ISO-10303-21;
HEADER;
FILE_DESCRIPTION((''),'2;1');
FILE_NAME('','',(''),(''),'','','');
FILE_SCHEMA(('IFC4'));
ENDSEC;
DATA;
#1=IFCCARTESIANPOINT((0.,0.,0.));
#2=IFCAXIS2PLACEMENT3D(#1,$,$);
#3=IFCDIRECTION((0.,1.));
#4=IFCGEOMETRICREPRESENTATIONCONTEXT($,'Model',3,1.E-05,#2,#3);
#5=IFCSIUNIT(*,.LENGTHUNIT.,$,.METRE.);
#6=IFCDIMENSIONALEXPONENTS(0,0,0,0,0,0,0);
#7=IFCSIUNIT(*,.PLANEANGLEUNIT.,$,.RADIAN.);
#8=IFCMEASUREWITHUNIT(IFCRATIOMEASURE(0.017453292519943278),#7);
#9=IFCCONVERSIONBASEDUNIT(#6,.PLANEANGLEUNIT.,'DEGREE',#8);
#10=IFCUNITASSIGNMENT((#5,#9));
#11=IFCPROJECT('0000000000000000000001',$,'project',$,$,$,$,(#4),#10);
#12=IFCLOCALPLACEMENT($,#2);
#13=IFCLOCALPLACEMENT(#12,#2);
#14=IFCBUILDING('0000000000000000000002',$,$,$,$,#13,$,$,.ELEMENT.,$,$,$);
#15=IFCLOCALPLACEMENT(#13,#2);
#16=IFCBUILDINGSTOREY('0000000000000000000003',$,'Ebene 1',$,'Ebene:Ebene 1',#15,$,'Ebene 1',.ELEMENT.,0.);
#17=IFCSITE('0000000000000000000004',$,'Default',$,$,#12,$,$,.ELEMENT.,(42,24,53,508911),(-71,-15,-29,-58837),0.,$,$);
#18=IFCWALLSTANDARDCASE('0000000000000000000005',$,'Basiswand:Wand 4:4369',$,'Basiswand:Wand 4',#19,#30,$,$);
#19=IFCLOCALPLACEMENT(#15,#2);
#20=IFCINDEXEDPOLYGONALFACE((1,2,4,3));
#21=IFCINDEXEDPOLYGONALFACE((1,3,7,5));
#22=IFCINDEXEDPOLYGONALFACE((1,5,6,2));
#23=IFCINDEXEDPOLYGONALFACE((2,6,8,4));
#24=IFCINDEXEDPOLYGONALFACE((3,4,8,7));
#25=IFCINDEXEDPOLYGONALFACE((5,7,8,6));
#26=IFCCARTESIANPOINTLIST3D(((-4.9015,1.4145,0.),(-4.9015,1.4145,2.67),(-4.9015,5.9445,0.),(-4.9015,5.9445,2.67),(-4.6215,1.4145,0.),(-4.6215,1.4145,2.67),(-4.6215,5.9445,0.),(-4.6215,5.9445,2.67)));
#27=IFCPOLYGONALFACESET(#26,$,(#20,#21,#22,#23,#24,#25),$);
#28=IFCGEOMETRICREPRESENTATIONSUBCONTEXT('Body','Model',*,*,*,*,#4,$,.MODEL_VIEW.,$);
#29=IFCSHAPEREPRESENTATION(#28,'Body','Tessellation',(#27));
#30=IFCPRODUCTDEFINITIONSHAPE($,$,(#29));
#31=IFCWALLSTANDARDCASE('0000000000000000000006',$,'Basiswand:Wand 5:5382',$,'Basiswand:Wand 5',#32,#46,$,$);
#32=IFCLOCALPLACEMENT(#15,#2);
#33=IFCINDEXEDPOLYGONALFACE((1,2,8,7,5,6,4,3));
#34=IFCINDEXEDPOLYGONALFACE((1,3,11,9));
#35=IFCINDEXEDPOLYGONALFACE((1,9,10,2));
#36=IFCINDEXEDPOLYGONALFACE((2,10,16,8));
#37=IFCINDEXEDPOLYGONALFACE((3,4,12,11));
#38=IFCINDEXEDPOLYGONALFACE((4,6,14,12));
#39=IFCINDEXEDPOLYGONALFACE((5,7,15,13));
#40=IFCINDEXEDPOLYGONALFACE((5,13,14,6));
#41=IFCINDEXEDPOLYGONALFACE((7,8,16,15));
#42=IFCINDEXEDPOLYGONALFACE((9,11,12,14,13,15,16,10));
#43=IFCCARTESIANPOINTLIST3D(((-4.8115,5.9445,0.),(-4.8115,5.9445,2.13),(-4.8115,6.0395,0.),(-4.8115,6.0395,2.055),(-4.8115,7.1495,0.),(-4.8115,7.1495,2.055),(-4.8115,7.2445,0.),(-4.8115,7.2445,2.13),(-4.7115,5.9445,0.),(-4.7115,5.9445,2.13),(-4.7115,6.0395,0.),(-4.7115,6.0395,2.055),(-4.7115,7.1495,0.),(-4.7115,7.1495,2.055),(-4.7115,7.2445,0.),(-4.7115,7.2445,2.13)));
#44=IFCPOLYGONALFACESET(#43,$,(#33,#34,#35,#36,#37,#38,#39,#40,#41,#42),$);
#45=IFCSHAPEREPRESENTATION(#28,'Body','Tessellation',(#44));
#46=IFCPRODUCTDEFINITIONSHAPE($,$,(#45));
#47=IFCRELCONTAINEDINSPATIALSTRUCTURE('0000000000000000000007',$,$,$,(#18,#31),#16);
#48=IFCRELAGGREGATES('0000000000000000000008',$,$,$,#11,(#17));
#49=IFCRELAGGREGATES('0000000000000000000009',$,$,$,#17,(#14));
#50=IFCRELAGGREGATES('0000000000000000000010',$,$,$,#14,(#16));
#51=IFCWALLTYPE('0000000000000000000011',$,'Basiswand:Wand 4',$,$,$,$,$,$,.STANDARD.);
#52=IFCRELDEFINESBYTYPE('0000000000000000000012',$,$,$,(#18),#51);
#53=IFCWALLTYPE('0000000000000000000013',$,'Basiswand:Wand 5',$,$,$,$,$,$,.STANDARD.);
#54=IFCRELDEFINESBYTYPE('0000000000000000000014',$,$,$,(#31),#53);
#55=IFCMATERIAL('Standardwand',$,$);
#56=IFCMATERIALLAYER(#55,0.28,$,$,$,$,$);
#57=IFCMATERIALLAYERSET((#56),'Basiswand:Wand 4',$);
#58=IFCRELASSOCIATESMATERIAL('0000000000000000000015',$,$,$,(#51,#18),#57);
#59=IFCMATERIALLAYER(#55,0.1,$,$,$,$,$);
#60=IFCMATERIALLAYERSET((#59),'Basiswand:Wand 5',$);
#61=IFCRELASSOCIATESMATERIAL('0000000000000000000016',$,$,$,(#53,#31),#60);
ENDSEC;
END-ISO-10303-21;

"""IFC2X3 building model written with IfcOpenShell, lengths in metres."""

from ifc_helpers import new_model, entity, si_unit, converted_unit, direction, frame, frame_2d, origin, place, context, subcontext, project, spatial, rectangle, extrude, material, layer, layer_set, layer_usage, type_object, element, save


model = new_model("IFC2X3")

# Units and contexts
model_context = context("Model", 3, precision=1e-05, world=origin(), true_north=direction((0.0, 1.0)))
body_context = subcontext(model_context, "Body", "Model", "MODEL_VIEW")
ifc_project = project(units=[si_unit("LENGTHUNIT", "METRE"), converted_unit("PLANEANGLEUNIT", "DEGREE", entity("IfcRatioMeasure", 0.017453292519943278), si_unit("PLANEANGLEUNIT", "RADIAN"), dimensions=[0, 0, 0, 0, 0, 0, 0])], contexts=[model_context])

# Site, building, storey
site_placement = place(None, origin())
site = spatial("IfcSite", under=ifc_project, at=site_placement, Name="Default", CompositionType="ELEMENT", RefLatitude=(42, 24, 53, 508911), RefLongitude=(-71, -15, -29, -58837), RefElevation=0.0)
building_placement = place(site_placement, origin())
building = spatial("IfcBuilding", under=site, at=building_placement, CompositionType="ELEMENT")
storey_placement = place(building_placement, origin())
storey = spatial("IfcBuildingStorey", under=building, at=storey_placement, Name="Ebene 1", ObjectType="Ebene:Ebene 1", LongName="Ebene 1", CompositionType="ELEMENT", Elevation=0.0)

# Shared definitions
ifc_material_1 = material(Name="Standardwand")

# Wall
ifc_layer_1 = layer(ifc_material_1, 0.28)
ifc_layer_set_1 = layer_set([ifc_layer_1], Name="Basiswand:Wand 4")
ifc_layer_usage_1 = layer_usage(ifc_layer_set_1, "AXIS2", "NEGATIVE", 0.14)
wall_type_1 = type_object("IfcWallType", Name="Basiswand:Wand 4", PredefinedType="STANDARD", material=ifc_layer_set_1)
wall_1_placement = place(storey_placement, frame((-4.7615, 5.9445, 0.0), z_axis=(0.0, 0.0, 1.0), x_axis=(0.0, -1.0, 0.0)))
element("IfcWallStandardCase", 1, at=wall_1_placement, inside=storey, type_object=wall_type_1, material=ifc_layer_usage_1, Name="Basiswand:Wand 4:4369", ObjectType="Basiswand:Wand 4", context=body_context, shape_type="SweptSolid", body=[
    extrude(rectangle(XDim=4.53, YDim=0.28, at=frame_2d((2.265, 0.0), x_axis=(-1.0, 0.0))), origin(), (0.0, 0.0, 1.0), 2.67),
])

# Wall, opening
ifc_layer_2 = layer(ifc_material_1, 0.1)
ifc_layer_set_2 = layer_set([ifc_layer_2], Name="Basiswand:Wand 5")
ifc_layer_usage_2 = layer_usage(ifc_layer_set_2, "AXIS2", "NEGATIVE", 0.05)
wall_type_2 = type_object("IfcWallType", Name="Basiswand:Wand 5", PredefinedType="STANDARD", material=ifc_layer_set_2)
wall_2_placement = place(storey_placement, frame((-4.7615, 5.9445, 0.0), z_axis=(0.0, 0.0, 1.0), x_axis=(0.0, 1.0, 0.0)))
wall_2 = element("IfcWallStandardCase", 2, at=wall_2_placement, inside=storey, type_object=wall_type_2, material=ifc_layer_usage_2, Name="Basiswand:Wand 5:5382", ObjectType="Basiswand:Wand 5", context=body_context, shape_type="SweptSolid", body=[
    extrude(rectangle(XDim=1.3, YDim=0.1, at=frame_2d((0.65, 0.0), x_axis=(-1.0, 0.0))), origin(), (0.0, 0.0, 1.0), 2.13),
])
opening_1_placement = place(wall_2_placement, frame((0.095, -0.05, -0.18)))
element("IfcOpeningElement", 3, at=opening_1_placement, cuts=wall_2, ObjectType="Opening", context=body_context, shape_type="SweptSolid", body=[
    extrude(rectangle(XDim=2.235, YDim=1.11, at=frame_2d((1.1175, 0.555), x_axis=(-1.0, 0.0))), frame((0.0, 0.0, 0.0), z_axis=(0.0, 1.0, 0.0), x_axis=(0.0, 0.0, 1.0)), (0.0, 0.0, 1.0), 0.1),
])

save(model, "model.ifc")
